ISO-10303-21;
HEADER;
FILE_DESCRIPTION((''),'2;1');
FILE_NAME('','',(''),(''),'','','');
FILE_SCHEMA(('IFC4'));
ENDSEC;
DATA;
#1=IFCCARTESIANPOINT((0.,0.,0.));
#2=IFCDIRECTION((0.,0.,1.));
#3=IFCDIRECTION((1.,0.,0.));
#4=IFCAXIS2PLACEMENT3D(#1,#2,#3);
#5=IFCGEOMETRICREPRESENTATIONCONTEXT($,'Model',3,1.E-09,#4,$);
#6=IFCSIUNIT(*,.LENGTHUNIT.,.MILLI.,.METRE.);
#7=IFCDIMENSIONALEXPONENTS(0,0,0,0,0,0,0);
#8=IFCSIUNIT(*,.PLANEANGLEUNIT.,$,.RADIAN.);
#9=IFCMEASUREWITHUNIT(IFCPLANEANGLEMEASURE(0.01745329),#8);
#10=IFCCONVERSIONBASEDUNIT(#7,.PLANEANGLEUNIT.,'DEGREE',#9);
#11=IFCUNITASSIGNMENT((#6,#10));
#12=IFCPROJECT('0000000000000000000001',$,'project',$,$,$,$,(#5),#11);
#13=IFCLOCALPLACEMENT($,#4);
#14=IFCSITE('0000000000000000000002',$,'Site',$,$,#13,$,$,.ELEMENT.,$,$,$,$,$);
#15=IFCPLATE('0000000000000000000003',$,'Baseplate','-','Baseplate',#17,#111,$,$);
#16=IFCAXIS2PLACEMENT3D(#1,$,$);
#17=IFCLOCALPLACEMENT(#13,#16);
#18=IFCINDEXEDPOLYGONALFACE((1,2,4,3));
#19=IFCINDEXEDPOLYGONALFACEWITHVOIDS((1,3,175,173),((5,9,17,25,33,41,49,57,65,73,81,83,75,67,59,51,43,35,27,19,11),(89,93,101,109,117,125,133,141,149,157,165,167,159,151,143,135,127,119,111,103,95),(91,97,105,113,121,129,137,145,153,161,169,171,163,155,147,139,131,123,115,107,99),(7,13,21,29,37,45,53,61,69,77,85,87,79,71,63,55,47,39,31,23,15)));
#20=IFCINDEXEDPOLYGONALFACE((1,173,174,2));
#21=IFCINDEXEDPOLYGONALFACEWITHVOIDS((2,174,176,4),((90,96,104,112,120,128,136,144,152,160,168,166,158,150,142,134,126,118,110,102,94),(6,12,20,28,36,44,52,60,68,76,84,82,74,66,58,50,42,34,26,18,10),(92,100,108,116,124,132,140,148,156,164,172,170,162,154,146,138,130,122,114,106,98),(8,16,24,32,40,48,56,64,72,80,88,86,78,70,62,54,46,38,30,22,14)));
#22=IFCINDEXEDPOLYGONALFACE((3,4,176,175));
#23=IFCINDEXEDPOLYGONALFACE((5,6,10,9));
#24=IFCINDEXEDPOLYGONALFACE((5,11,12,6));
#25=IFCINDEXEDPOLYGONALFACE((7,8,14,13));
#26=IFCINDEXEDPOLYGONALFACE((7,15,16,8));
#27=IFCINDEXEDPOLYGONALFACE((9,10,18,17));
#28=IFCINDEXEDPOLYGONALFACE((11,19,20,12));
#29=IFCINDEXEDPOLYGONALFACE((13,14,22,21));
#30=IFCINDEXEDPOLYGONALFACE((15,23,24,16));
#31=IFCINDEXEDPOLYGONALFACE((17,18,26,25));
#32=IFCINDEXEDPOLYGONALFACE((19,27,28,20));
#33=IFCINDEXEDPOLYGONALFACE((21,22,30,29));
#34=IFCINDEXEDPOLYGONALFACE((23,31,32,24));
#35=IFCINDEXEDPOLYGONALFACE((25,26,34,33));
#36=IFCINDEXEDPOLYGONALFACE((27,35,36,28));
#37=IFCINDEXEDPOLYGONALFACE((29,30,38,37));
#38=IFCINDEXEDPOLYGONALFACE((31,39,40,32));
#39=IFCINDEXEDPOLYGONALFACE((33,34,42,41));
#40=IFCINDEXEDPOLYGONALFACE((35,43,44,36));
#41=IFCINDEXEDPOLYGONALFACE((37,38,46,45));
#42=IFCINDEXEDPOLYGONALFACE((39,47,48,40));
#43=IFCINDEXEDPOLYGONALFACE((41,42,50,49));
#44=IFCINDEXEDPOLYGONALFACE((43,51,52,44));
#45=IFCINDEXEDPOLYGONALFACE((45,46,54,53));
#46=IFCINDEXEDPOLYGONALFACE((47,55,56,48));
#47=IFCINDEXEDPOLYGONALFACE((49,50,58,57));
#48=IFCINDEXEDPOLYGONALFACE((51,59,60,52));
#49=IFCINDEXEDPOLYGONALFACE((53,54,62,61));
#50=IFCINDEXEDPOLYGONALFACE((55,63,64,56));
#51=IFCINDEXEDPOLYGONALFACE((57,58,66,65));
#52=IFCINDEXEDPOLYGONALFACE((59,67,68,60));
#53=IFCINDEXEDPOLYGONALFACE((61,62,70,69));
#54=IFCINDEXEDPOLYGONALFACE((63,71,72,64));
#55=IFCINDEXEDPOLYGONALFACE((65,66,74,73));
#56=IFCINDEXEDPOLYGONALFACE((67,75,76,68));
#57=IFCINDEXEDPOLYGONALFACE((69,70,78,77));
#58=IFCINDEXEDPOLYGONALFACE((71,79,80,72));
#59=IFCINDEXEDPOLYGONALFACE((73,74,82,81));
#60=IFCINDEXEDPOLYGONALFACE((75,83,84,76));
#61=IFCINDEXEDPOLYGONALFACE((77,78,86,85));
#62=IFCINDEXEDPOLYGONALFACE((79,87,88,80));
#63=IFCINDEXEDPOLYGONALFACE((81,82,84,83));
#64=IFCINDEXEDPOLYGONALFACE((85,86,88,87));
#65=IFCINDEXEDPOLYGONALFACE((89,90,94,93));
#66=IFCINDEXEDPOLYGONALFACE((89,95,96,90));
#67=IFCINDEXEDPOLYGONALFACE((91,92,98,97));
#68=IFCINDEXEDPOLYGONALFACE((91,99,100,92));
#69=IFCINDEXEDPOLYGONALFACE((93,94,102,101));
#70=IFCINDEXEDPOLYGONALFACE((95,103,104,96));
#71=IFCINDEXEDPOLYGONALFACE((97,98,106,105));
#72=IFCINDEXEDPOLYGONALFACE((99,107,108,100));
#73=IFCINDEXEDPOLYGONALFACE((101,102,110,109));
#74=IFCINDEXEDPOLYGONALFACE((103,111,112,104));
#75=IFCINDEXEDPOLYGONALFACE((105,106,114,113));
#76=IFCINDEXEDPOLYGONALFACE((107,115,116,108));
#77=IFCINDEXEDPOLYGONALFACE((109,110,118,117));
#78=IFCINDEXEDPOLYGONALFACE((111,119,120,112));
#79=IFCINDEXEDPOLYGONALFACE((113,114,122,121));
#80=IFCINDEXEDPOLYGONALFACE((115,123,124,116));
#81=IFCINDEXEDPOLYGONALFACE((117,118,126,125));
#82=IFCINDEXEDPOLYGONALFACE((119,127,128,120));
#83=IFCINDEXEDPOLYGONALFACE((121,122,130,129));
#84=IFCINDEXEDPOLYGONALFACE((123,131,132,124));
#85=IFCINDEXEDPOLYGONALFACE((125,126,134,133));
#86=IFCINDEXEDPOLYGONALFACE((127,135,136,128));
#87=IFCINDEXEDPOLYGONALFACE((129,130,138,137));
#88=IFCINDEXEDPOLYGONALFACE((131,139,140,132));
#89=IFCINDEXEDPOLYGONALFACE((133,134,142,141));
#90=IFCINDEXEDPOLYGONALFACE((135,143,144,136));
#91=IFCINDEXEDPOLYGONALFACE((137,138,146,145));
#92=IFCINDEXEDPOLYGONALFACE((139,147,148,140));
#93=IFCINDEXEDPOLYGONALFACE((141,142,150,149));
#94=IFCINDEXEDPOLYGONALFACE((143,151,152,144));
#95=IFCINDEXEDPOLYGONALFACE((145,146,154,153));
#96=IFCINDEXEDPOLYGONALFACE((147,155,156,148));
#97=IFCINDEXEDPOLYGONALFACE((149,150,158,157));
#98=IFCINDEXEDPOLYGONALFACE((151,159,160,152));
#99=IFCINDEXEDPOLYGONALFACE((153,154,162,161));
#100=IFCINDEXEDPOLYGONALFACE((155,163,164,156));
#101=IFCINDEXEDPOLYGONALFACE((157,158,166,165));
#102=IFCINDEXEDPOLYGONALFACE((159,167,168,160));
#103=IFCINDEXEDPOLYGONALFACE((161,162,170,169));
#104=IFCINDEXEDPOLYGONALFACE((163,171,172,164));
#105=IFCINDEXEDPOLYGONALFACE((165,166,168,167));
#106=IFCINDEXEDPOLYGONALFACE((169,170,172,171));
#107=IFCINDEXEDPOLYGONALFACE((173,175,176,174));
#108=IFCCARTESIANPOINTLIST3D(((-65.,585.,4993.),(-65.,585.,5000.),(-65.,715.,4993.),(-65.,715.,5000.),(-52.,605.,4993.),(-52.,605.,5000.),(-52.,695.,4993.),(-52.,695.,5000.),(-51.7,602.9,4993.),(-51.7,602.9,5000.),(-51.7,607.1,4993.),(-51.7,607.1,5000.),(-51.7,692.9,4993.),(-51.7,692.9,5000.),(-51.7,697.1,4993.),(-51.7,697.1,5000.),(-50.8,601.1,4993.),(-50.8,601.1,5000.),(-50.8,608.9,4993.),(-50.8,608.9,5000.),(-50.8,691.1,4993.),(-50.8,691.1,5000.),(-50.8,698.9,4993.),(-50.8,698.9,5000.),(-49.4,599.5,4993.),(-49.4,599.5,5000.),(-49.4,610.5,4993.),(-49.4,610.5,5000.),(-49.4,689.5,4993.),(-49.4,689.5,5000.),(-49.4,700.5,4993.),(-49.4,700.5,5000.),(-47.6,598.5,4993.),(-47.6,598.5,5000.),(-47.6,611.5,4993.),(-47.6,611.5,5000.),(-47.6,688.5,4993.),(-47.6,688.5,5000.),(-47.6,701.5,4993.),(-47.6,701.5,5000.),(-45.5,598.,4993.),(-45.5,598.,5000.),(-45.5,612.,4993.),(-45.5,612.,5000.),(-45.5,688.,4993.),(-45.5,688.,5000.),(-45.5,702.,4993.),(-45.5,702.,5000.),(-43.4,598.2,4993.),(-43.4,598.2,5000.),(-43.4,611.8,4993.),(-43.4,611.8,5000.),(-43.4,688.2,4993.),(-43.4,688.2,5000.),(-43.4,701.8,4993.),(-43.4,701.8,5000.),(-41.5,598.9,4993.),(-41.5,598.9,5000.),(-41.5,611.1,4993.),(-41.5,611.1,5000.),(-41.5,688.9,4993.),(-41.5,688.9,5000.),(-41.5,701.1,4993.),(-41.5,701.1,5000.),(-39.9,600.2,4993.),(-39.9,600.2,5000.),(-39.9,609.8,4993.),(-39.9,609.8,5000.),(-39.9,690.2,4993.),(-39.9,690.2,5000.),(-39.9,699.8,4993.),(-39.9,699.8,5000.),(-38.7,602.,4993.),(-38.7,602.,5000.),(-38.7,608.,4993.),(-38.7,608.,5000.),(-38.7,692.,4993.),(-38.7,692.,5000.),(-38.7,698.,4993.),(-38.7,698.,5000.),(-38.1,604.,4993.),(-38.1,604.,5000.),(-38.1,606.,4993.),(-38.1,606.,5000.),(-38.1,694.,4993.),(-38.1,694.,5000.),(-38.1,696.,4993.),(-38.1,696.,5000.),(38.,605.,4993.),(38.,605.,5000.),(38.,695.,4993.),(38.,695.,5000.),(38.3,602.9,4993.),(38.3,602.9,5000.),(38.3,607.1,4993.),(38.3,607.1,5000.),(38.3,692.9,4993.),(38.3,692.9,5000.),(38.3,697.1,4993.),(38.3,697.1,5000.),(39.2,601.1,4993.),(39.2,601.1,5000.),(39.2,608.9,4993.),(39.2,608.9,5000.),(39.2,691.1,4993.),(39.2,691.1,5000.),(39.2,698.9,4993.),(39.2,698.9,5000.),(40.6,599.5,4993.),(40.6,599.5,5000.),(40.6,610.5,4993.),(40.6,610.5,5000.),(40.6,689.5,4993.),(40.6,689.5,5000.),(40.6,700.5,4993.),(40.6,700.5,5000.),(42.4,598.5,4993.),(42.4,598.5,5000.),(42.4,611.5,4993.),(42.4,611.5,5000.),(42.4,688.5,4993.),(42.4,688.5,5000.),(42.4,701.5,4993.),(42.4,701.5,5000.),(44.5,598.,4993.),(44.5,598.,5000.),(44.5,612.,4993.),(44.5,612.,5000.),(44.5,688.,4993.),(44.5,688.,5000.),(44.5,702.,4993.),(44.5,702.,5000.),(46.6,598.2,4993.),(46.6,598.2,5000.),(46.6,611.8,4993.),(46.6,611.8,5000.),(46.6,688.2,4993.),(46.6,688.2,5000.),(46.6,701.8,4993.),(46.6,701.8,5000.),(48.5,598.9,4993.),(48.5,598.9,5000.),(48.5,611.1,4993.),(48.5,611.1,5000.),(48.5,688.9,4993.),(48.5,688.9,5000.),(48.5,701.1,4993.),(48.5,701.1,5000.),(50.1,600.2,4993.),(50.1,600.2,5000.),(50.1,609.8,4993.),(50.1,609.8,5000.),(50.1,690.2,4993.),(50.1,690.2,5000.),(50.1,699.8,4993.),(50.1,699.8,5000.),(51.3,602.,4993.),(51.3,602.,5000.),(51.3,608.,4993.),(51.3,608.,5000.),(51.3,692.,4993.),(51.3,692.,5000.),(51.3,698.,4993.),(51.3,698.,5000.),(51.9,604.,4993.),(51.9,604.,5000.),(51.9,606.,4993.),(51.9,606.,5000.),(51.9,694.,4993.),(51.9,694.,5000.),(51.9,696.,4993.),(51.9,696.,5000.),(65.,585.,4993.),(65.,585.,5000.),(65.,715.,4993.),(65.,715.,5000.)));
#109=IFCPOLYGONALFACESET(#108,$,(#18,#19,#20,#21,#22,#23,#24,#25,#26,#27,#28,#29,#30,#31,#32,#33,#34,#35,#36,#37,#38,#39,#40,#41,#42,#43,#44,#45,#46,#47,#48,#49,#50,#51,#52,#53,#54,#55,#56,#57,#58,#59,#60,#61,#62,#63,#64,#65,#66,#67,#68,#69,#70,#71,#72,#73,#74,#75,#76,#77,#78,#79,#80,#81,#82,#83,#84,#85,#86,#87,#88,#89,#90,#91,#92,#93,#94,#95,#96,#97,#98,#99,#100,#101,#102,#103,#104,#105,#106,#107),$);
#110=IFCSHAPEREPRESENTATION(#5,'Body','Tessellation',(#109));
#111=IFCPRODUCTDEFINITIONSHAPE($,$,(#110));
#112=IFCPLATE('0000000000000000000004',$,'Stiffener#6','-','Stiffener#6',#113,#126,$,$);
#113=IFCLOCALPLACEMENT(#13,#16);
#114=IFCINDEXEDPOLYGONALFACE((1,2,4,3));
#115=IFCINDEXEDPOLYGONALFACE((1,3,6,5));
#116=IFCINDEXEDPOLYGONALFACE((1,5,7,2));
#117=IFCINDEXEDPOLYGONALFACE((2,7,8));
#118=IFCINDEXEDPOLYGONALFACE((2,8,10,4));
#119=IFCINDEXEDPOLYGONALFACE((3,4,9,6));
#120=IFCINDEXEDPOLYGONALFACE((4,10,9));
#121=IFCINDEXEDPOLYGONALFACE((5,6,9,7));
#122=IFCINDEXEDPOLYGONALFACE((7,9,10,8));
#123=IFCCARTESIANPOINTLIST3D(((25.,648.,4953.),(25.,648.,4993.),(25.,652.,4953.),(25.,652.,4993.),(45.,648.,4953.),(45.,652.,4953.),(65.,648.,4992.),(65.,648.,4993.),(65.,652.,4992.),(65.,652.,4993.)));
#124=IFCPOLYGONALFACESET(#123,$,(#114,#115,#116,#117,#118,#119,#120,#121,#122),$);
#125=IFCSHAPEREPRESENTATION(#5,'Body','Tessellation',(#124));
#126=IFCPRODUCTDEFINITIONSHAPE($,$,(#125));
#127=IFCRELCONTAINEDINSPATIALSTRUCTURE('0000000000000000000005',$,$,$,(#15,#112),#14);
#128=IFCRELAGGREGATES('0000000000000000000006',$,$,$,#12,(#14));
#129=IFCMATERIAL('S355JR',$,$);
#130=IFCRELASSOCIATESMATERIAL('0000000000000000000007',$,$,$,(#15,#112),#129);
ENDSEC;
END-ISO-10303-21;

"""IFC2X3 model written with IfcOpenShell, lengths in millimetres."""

from ifc_helpers import new_model, entity, si_unit, converted_unit, frame, frame_2d, origin, origin_with_axes, place, context, project, spatial, polyline, circle, outline, extrude, material, element, save


model = new_model("IFC2X3")

# Units and contexts
model_context = context("Model", 3, precision=1e-09, world=origin_with_axes())
ifc_project = project(units=[si_unit("LENGTHUNIT", "METRE", prefix="MILLI"), converted_unit("PLANEANGLEUNIT", "DEGREE", entity("IfcPlaneAngleMeasure", 0.01745329), si_unit("PLANEANGLEUNIT", "RADIAN"), dimensions=[0, 0, 0, 0, 0, 0, 0])], contexts=[model_context])

# Site
site_placement = place(None, origin_with_axes())
site = spatial("IfcSite", under=ifc_project, at=site_placement, Name="Site", CompositionType="ELEMENT")

# Shared definitions
ifc_material = material(Name="S355JR")

# Plate, openings
plate_1_placement = place(None, frame((65.0, 715.0, 4993.0), z_axis=(0.0, 0.0, 1.0), x_axis=(-1.0, 0.0, 0.0)))
plate_1 = element("IfcPlate", 1, at=plate_1_placement, inside=site, material=ifc_material, Name="Baseplate", Description="-", ObjectType="Baseplate", context=model_context, shape_type="SweptSolid", body=[
    extrude(outline(polyline([(0.0, 0.0), (130.0, 0.0), (130.0, 130.0), (0.0, 130.0), (0.0, 0.0)])), origin_with_axes(), (0.0, 0.0, 1.0), 7.0),
])
opening_1_placement = place(plate_1_placement, frame((110.0, 65.0, 7.5), z_axis=(0.0, 0.0, -1.0), x_axis=(1.0, 0.0, 0.0)))
element("IfcOpeningElement", 2, at=opening_1_placement, cuts=plate_1, ObjectType="Opening", context=model_context, shape_type="SweptSolid", body=[
    extrude(circle(Radius=7.0, at=frame_2d((0.0, 45.0), x_axis=(1.0, 0.0))), origin(), (0.0, 0.0, 1.0), 8.0),
])
opening_2_placement = place(plate_1_placement, frame((110.0, 65.0, 7.5), z_axis=(0.0, 0.0, -1.0), x_axis=(1.0, 0.0, 0.0)))
element("IfcOpeningElement", 3, at=opening_2_placement, cuts=plate_1, ObjectType="Opening", context=model_context, shape_type="SweptSolid", body=[
    extrude(circle(Radius=7.0, at=frame_2d((0.0, -45.0), x_axis=(1.0, 0.0))), origin(), (0.0, 0.0, 1.0), 8.0),
])
opening_3_placement = place(plate_1_placement, frame((20.0, 65.0, 7.5), z_axis=(0.0, 0.0, -1.0), x_axis=(1.0, 0.0, 0.0)))
element("IfcOpeningElement", 4, at=opening_3_placement, cuts=plate_1, ObjectType="Opening", context=model_context, shape_type="SweptSolid", body=[
    extrude(circle(Radius=7.0, at=frame_2d((0.0, 45.0), x_axis=(1.0, 0.0))), origin(), (0.0, 0.0, 1.0), 8.0),
])
opening_4_placement = place(plate_1_placement, frame((20.0, 65.0, 7.5), z_axis=(0.0, 0.0, -1.0), x_axis=(1.0, 0.0, 0.0)))
element("IfcOpeningElement", 5, at=opening_4_placement, cuts=plate_1, ObjectType="Opening", context=model_context, shape_type="SweptSolid", body=[
    extrude(circle(Radius=7.0, at=frame_2d((0.0, -45.0), x_axis=(1.0, 0.0))), origin(), (0.0, 0.0, 1.0), 8.0),
])

# Plate, opening
plate_2_placement = place(None, frame((25.0, 648.0, 4993.0), z_axis=(0.0, 1.0, 0.0), x_axis=(1.0, 0.0, 0.0)))
plate_2 = element("IfcPlate", 6, at=plate_2_placement, inside=site, material=ifc_material, Name="Stiffener#6", Description="-", ObjectType="Stiffener#6", context=model_context, shape_type="SweptSolid", body=[
    extrude(outline(polyline([(0.0, 0.0), (40.0, 0.0), (40.0, 40.0), (0.0, 40.0), (0.0, 0.0)])), origin_with_axes(), (0.0, 0.0, 1.0), 4.0),
])
opening_5_placement = place(plate_2_placement, frame((0.0, 0.0, 0.0), z_axis=(0.0, 0.0, 1.0), x_axis=(1.0, 0.0, 0.0)))
element("IfcOpeningElement", 7, at=opening_5_placement, cuts=plate_2, ObjectType="Opening", context=model_context, shape_type="SweptSolid", body=[
    extrude(outline(polyline([(40.0, 40.0), (20.0, 40.0), (40.0, 1.0), (40.0, 40.0)])), origin(), (0.0, 0.0, 1.0), 4.0),
])

save(model, "model.ifc")
